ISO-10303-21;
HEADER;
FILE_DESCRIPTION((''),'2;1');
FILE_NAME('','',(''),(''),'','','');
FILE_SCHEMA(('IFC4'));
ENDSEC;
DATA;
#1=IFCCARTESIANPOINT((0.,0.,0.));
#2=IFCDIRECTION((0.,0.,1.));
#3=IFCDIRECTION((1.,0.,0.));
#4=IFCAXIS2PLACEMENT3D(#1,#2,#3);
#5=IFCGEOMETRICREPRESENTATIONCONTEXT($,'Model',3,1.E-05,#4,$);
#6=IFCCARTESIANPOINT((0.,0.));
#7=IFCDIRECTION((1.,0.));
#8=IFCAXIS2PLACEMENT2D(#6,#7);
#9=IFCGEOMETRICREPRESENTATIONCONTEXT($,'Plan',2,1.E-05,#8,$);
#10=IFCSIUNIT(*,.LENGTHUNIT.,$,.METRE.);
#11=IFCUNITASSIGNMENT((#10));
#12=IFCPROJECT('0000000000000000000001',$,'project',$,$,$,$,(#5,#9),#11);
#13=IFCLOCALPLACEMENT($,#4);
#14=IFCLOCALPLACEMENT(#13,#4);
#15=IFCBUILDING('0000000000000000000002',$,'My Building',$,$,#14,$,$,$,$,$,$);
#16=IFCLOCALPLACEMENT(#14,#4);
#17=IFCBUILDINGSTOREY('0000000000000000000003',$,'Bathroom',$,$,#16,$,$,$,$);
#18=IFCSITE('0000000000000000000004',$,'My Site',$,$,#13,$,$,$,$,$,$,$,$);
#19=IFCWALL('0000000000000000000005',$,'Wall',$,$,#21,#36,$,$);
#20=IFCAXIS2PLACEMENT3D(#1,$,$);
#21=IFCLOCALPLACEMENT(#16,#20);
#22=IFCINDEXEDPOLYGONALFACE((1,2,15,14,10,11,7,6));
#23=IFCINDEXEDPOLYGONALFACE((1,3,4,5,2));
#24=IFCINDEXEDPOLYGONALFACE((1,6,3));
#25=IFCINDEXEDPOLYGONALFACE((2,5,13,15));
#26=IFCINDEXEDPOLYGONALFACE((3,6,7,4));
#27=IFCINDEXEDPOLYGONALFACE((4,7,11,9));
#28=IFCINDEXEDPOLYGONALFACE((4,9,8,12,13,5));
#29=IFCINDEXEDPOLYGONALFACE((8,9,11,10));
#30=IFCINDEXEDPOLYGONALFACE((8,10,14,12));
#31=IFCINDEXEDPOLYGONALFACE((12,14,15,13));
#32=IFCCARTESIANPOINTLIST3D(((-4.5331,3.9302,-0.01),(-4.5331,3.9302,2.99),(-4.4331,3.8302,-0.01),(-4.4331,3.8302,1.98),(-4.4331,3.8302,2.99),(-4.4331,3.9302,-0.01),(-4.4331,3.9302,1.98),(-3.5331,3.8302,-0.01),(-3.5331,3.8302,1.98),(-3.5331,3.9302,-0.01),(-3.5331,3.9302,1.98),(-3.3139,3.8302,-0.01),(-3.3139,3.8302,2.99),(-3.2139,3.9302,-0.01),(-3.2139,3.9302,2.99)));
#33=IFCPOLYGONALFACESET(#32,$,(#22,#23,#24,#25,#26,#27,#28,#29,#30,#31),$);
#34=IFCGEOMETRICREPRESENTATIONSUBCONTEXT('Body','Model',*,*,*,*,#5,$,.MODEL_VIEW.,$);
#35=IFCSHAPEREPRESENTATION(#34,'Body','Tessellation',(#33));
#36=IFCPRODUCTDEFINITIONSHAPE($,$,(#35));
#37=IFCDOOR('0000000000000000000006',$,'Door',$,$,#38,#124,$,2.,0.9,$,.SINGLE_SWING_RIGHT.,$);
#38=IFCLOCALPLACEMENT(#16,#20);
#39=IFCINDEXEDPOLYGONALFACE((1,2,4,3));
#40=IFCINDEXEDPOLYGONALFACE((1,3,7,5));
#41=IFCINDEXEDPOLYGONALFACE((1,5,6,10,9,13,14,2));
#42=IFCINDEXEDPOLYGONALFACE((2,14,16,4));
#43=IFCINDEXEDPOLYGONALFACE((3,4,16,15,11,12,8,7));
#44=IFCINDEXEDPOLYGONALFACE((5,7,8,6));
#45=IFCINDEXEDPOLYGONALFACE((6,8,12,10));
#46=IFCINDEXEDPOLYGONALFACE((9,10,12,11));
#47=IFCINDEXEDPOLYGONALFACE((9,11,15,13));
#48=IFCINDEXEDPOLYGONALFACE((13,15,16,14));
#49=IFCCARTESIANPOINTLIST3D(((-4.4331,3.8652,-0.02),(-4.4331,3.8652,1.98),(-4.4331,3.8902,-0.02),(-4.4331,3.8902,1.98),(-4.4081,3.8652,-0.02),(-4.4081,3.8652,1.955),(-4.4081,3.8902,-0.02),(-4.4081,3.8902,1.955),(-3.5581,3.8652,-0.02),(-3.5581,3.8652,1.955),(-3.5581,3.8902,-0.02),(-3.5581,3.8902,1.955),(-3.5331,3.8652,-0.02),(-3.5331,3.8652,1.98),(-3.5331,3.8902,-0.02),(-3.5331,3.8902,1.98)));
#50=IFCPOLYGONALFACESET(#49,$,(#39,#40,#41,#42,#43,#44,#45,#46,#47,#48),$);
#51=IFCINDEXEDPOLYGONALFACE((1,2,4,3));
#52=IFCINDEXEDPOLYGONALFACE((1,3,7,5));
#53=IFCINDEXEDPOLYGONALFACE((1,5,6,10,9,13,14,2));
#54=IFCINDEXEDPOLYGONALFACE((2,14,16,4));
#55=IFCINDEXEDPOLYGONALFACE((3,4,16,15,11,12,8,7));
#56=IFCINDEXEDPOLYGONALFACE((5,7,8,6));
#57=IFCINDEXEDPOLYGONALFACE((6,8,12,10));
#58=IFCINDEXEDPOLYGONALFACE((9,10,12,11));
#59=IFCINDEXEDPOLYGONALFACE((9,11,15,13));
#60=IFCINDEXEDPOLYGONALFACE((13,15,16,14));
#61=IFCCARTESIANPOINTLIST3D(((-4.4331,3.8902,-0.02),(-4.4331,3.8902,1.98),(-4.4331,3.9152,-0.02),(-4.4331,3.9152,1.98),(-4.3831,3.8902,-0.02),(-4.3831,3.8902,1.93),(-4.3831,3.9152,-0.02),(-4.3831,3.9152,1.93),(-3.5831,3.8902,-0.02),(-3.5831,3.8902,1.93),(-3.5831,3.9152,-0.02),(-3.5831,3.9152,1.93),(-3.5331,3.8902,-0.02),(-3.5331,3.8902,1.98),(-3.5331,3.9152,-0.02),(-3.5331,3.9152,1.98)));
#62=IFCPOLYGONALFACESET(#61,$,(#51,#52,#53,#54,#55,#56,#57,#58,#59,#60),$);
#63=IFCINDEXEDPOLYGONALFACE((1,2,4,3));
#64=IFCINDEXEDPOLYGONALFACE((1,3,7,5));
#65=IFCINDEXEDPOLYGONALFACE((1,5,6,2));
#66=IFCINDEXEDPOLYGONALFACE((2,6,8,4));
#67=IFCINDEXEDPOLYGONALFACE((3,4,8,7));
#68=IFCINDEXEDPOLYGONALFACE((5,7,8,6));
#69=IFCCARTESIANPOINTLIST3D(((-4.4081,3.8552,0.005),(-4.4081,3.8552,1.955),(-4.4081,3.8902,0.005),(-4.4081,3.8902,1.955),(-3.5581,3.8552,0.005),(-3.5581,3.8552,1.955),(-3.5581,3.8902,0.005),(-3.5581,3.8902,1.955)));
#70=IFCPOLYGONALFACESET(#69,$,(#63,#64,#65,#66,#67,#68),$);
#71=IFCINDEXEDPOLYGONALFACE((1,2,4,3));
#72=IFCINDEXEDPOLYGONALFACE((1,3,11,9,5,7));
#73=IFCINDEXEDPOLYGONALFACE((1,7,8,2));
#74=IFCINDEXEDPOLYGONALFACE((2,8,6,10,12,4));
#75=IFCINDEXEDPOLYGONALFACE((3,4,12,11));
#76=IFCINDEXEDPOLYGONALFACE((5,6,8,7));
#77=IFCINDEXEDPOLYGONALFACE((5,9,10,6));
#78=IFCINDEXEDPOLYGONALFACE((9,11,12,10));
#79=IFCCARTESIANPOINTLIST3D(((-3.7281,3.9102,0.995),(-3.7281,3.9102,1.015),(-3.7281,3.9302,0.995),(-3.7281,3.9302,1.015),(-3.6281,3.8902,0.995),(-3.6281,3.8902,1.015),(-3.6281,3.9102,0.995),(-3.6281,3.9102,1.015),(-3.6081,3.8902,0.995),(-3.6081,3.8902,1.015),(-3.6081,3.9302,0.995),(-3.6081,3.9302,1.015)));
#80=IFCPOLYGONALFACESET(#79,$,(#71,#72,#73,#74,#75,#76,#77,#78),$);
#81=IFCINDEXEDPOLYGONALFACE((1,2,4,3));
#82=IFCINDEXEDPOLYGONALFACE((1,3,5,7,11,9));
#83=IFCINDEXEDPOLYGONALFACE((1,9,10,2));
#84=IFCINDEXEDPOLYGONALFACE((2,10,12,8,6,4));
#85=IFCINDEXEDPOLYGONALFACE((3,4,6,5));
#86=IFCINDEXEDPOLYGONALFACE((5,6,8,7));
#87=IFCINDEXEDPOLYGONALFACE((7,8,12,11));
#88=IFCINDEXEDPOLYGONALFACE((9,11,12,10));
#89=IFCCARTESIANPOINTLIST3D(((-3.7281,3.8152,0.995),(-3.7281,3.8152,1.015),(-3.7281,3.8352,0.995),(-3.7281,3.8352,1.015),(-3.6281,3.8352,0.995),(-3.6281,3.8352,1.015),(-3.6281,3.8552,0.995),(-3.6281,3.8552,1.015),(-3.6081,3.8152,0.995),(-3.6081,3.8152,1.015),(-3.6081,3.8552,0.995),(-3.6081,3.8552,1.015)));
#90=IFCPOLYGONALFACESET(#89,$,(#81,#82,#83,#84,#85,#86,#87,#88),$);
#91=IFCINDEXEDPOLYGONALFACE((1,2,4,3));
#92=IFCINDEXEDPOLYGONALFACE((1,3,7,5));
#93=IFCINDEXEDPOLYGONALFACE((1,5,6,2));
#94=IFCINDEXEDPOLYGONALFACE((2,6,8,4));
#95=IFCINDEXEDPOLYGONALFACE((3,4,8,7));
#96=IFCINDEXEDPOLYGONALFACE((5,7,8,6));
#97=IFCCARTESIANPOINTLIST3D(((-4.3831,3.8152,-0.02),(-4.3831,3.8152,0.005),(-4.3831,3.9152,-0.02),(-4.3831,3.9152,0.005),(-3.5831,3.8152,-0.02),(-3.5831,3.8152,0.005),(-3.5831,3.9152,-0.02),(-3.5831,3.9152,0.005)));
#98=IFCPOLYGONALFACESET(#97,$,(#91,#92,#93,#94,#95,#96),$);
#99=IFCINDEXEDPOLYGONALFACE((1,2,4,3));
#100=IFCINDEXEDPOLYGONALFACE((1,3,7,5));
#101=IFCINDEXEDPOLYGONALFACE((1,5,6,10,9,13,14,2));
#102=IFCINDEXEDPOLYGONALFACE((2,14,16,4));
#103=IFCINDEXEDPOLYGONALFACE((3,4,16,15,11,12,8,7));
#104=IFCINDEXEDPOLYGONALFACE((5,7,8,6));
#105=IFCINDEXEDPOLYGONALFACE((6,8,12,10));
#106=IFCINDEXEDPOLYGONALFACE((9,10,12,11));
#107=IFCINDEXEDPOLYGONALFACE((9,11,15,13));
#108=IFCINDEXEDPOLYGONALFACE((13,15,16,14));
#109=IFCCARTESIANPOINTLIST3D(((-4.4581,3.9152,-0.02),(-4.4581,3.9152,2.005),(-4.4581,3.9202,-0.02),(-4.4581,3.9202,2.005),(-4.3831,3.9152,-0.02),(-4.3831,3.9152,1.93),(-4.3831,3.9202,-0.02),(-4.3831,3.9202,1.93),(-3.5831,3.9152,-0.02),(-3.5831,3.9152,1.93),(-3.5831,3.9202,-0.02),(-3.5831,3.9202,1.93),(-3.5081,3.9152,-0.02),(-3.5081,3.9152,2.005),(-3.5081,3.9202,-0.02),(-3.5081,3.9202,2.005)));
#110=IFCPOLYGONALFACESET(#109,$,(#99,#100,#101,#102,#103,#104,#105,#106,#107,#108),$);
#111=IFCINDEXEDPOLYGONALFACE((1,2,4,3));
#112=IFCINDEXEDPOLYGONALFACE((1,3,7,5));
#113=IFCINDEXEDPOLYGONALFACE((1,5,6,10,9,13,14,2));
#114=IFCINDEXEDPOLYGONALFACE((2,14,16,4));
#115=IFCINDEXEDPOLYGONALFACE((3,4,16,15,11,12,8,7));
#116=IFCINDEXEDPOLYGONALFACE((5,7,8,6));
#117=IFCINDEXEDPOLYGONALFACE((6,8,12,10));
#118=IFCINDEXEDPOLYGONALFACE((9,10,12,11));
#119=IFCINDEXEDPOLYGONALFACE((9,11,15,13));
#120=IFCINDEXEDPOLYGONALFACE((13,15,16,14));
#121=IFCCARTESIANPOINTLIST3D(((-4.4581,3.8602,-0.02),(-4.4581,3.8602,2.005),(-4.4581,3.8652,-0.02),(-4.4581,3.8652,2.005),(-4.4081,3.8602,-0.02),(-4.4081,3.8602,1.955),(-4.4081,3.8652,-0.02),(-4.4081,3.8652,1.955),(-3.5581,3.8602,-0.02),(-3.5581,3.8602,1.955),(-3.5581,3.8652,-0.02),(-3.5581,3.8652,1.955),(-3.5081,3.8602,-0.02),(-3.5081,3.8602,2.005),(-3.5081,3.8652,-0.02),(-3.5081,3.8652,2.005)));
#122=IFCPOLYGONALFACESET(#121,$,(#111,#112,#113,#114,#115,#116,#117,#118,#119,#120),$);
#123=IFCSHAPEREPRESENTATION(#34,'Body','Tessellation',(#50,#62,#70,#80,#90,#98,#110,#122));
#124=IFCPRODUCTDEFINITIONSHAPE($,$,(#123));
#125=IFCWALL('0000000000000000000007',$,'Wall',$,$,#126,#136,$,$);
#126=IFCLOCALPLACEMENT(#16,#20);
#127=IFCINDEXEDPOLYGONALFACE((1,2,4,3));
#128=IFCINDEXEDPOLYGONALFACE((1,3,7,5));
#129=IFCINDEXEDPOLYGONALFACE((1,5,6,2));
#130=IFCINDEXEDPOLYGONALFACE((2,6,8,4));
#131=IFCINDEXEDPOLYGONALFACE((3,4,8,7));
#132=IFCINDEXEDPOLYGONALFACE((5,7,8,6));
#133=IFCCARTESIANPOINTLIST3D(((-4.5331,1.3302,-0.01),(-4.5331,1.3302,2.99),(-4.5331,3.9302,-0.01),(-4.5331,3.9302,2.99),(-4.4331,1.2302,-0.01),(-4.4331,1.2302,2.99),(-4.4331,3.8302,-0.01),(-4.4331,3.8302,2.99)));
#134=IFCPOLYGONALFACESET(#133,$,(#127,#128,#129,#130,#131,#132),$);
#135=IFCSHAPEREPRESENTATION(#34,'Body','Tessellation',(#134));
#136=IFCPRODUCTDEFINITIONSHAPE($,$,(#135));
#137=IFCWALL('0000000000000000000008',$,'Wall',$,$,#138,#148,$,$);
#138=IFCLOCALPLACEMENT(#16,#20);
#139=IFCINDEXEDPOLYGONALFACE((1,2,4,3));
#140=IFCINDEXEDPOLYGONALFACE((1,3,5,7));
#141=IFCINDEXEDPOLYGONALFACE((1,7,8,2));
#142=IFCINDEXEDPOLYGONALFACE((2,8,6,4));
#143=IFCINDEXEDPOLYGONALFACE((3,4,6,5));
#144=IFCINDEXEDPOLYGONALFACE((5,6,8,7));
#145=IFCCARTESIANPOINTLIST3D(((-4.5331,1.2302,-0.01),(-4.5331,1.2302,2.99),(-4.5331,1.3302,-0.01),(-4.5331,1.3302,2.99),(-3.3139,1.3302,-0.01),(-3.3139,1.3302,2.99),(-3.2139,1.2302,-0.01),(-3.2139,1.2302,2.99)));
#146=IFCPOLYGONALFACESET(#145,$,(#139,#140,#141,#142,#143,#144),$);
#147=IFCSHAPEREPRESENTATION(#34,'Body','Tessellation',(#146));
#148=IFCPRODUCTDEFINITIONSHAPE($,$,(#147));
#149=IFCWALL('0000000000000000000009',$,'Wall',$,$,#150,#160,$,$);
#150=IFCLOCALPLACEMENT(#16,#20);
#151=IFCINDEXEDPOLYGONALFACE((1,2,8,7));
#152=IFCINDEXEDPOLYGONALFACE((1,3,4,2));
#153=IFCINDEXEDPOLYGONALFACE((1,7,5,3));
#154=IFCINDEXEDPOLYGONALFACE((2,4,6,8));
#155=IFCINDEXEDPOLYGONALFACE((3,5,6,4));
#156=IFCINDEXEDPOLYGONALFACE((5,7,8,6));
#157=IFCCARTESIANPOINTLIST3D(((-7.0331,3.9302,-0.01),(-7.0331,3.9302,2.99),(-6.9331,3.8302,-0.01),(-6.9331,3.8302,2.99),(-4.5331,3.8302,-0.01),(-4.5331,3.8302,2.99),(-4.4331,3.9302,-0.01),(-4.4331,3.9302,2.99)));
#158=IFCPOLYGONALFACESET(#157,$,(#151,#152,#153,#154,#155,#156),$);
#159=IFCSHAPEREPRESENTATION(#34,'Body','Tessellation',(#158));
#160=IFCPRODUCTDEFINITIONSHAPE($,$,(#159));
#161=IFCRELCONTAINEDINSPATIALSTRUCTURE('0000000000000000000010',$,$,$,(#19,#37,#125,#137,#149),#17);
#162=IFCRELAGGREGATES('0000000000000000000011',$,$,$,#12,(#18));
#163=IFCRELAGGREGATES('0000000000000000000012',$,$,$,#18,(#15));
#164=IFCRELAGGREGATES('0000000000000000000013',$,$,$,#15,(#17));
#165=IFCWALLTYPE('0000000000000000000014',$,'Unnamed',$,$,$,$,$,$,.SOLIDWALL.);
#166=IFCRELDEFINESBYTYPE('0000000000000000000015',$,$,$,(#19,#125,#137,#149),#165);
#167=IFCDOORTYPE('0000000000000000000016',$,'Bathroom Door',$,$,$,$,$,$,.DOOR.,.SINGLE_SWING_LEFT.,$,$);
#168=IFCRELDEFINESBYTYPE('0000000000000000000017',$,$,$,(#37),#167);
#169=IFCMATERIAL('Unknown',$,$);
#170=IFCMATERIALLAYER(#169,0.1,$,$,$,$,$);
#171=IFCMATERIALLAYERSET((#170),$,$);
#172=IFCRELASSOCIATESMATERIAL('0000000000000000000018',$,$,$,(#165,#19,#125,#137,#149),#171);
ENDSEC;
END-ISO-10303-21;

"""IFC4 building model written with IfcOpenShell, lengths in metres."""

from ifc_helpers import new_model, entity, si_unit, frame, origin_with_axes, origin_2d_with_axis, place, context, subcontext, project, spatial, line, indexed_curve, outline, extrude, shape, source, transform, mapped, material, layer, layer_set, layer_usage, type_object, type_shapes, element, fill, save


model = new_model("IFC4")

# Units and contexts
model_context = context("Model", 3, precision=1e-05, world=origin_with_axes())
plan_context = context("Plan", 2, precision=1e-05, world=origin_2d_with_axis())
body_context_1 = subcontext(model_context, "Body", "Model", "MODEL_VIEW")
body_context_2 = subcontext(plan_context, "Body", "Plan", "PLAN_VIEW")
ifc_project = project(units=[si_unit("LENGTHUNIT", "METRE")], contexts=[model_context, plan_context])

# Site, building, storey
site_placement = place(None, origin_with_axes())
site = spatial("IfcSite", under=ifc_project, at=site_placement, Name="My Site")
building_placement = place(site_placement, origin_with_axes())
building = spatial("IfcBuilding", under=site, at=building_placement, Name="My Building")
storey_placement = place(building_placement, origin_with_axes())
storey = spatial("IfcBuildingStorey", under=building, at=storey_placement, Name="Bathroom")

# Shared definitions
ifc_material = material(Name="Unknown")

# Shared definitions
ifc_layer_1 = layer(ifc_material, 0.1)
ifc_layer_set_1 = layer_set([ifc_layer_1])
wall_type = type_object("IfcWallType", Name="Unnamed", PredefinedType="SOLIDWALL", material=ifc_layer_set_1)

# Shared definitions
shared_shape_1 = source(origin_with_axes(), body_context_1, "Body", "SweptSolid", [
    extrude(outline(indexed_curve([(0.0, 0.0), (0.9, 0.0), (0.9, 2.0), (0.0, 2.0)], segments=[line(1, 2, 3, 4, 1)])), frame((0.0, -0.6, 0.0), z_axis=(0.0, -1.0, 0.0), x_axis=(1.0, 0.0, 0.0)), (0.0, 0.0, -1.0), 1.2),
])
door_type = type_object("IfcDoorType", Name="Bathroom Door", OperationType="SINGLE_SWING_LEFT", PredefinedType="DOOR")
shared_shape_2 = source(origin_with_axes(), body_context_1, "Body", "SweptSolid", [
    extrude(outline(indexed_curve([(0.0, 0.0), (0.0, 2.0), (0.9, 2.0), (0.9, 0.0), (0.875, 0.0), (0.875, 1.975), (0.025, 1.975), (0.025, 0.0)], segments=[line(1, 2, 3, 4, 5, 6, 7, 8, 1)])), frame((0.0, 0.025, 0.0), z_axis=(0.0, -1.0, 0.0), x_axis=(1.0, 0.0, 0.0)), (0.0, 0.0, -1.0), 0.025),
    extrude(outline(indexed_curve([(0.0, 0.0), (0.0, 2.0), (0.9, 2.0), (0.9, 0.0), (0.85, 0.0), (0.85, 1.95), (0.05, 1.95), (0.05, 0.0)], segments=[line(1, 2, 3, 4, 5, 6, 7, 8, 1)])), frame((0.0, 0.0, 0.0), z_axis=(0.0, -1.0, 0.0), x_axis=(1.0, 0.0, 0.0)), (0.0, 0.0, -1.0), 0.025),
    extrude(outline(indexed_curve([(0.0, 0.0), (0.85, 0.0), (0.85, 0.035), (0.0, 0.035)], segments=[line(1, 2, 3, 4, 1)])), frame((0.025, 0.025, 0.025), z_axis=(0.0, 0.0, 1.0), x_axis=(1.0, 0.0, 0.0)), (0.0, 0.0, 1.0), 1.95),
    extrude(outline(indexed_curve([(0.0, 0.0), (0.0, -0.04), (0.12, -0.04), (0.12, -0.02), (0.02, -0.02), (0.02, 0.0)], segments=[line(1, 2, 3, 4, 5, 6, 1)])), frame((0.075, 0.025, 1.015), z_axis=(0.0, 0.0, 1.0), x_axis=(1.0, 0.0, 0.0)), (0.0, 0.0, 1.0), 0.02),
    extrude(outline(indexed_curve([(0.0, 0.0), (0.0, 0.04), (0.12, 0.04), (0.12, 0.02), (0.02, 0.02), (0.02, 0.0)], segments=[line(1, 2, 3, 4, 5, 6, 1)])), frame((0.075, 0.06, 1.015), z_axis=(0.0, 0.0, 1.0), x_axis=(1.0, 0.0, 0.0)), (0.0, 0.0, 1.0), 0.02),
    extrude(outline(indexed_curve([(0.0, 0.0), (0.8, 0.0), (0.8, 0.1), (0.0, 0.1)], segments=[line(1, 2, 3, 4, 1)])), frame((0.05, 0.0, 0.0), z_axis=(0.0, 0.0, 1.0), x_axis=(1.0, 0.0, 0.0)), (0.0, 0.0, 1.0), 0.025),
    extrude(outline(indexed_curve([(0.0, 0.0), (0.0, 2.025), (0.95, 2.025), (0.95, 0.0), (0.875, 0.0), (0.875, 1.95), (0.075, 1.95), (0.075, 0.0)], segments=[line(1, 2, 3, 4, 5, 6, 7, 8, 1)])), frame((-0.025, -0.005, 0.0), z_axis=(0.0, -1.0, 0.0), x_axis=(1.0, 0.0, 0.0)), (0.0, 0.0, -1.0), 0.005),
    extrude(outline(indexed_curve([(0.0, 0.0), (0.0, 2.025), (0.95, 2.025), (0.95, 0.0), (0.9, 0.0), (0.9, 1.975), (0.05, 1.975), (0.05, 0.0)], segments=[line(1, 2, 3, 4, 5, 6, 7, 8, 1)])), frame((-0.025, 0.05, 0.0), z_axis=(0.0, -1.0, 0.0), x_axis=(1.0, 0.0, 0.0)), (0.0, 0.0, -1.0), 0.005),
])
shared_shape_3 = source(origin_with_axes(), body_context_2, "Body", "Curve2D", [
    entity("IfcIndexedPolyCurve", entity("IfcCartesianPointList2D", [[0.0, 0.0], [0.0, 0.05], [0.025, 0.05], [0.025, 0.025], [0.05, 0.025], [0.05, 0.0]]), [entity("IfcLineIndex", [1, 2, 3, 4, 5, 6, 1])]),
    entity("IfcIndexedPolyCurve", entity("IfcCartesianPointList2D", [[0.9, 0.0], [0.9, 0.05], [0.875, 0.05], [0.875, 0.025], [0.85, 0.025], [0.85, 0.0]]), [entity("IfcLineIndex", [1, 2, 3, 4, 5, 6, 1])]),
    entity("IfcTrimmedCurve", entity("IfcEllipse", entity("IfcAxis2Placement2D", entity("IfcCartesianPoint", [0.84, 0.05]), entity("IfcDirection", [1.0, 0.0])), 0.815, 0.85), [entity("IfcCartesianPoint", [0.84, 0.9])], [entity("IfcCartesianPoint", [0.025, 0.05])], True, "CARTESIAN"),
    entity("IfcIndexedPolyCurve", entity("IfcCartesianPointList2D", [[0.875, 0.05], [0.84, 0.05], [0.84, 0.9], [0.875, 0.9]]), [entity("IfcLineIndex", [1, 2, 3, 4, 1])]),
])
type_shapes(door_type, [shared_shape_2, shared_shape_3])

# Wall, opening, door
ifc_layer_usage_1 = layer_usage(ifc_layer_set_1, "AXIS2", "POSITIVE", 0.0)
wall_1_placement = place(storey_placement, frame((-3.2139, 3.9302, -0.01), z_axis=(0.0, 0.0, 1.0), x_axis=(-1.0, 0.0, 0.0)))
wall_1 = element("IfcWall", 1, at=wall_1_placement, inside=storey, type_object=wall_type, material=ifc_layer_usage_1, Name="Wall", context=body_context_1, shape_type="SweptSolid", body=[
    extrude(outline(indexed_curve([(0.0, 0.0), (0.1, 0.1), (1.2192, 0.1), (1.3192, 0.0)], segments=[line(1, 2, 3, 4, 1)])), origin_with_axes(), (0.0, 0.0, 1.0), 3.0),
])
opening_1_placement = place(wall_1_placement, frame((0.3192, 0.015, -0.01), z_axis=(0.0, 0.0, 1.0), x_axis=(1.0, 0.0, 0.0)))
opening_1 = element("IfcOpeningElement", 2, at=opening_1_placement, cuts=wall_1, PredefinedType="OPENING", context=body_context_1, shape_type="MappedRepresentation", body=[
    mapped(shared_shape_1, transform((0.0, 0.0, 0.0), x_axis=(1.0, 0.0, 0.0), y_axis=(0.0, 1.0, 0.0), z_axis=(0.0, 0.0, 1.0), scale=1.0)),
])
door_1_placement = place(opening_1_placement, origin_with_axes())
door_1 = element("IfcDoor", 3, at=door_1_placement, inside=storey, type_object=door_type, Name="Door", OperationType="SINGLE_SWING_RIGHT", OverallHeight=2.0, OverallWidth=0.9, shapes=[
    shape(body_context_1, "Body", "MappedRepresentation", [mapped(shared_shape_2, transform((0.0, 0.0, 0.0), x_axis=(1.0, 0.0, 0.0), y_axis=(0.0, 1.0, 0.0), z_axis=(0.0, 0.0, 1.0), scale=1.0))]),
    shape(body_context_2, "Body", "MappedRepresentation", [mapped(shared_shape_3, transform((0.0, 0.0, 0.0), x_axis=(1.0, 0.0, 0.0), y_axis=(0.0, 1.0, 0.0), z_axis=(0.0, 0.0, 1.0), scale=1.0))]),
])
fill(opening_1, door_1)

# Walls
ifc_layer_usage_2 = layer_usage(ifc_layer_set_1, "AXIS2", "POSITIVE", 0.0)
wall_2_placement = place(storey_placement, frame((-4.5331, 3.9302, -0.01), z_axis=(0.0, 0.0, 1.0), x_axis=(0.0, -1.0, 0.0)))
element("IfcWall", 4, at=wall_2_placement, inside=storey, type_object=wall_type, material=ifc_layer_usage_2, Name="Wall", context=body_context_1, shape_type="SweptSolid", body=[
    extrude(outline(indexed_curve([(0.0, 0.0), (0.1, 0.1), (2.7, 0.1), (2.6, 0.0)], segments=[line(1, 2, 3, 4, 1)])), origin_with_axes(), (0.0, 0.0, 1.0), 3.0),
])
ifc_layer_usage_3 = layer_usage(ifc_layer_set_1, "AXIS2", "POSITIVE", 0.0)
wall_3_placement = place(storey_placement, frame((-4.5331, 1.2302, -0.01), z_axis=(0.0, 0.0, 1.0), x_axis=(1.0, 0.0, 0.0)))
element("IfcWall", 5, at=wall_3_placement, inside=storey, type_object=wall_type, material=ifc_layer_usage_3, Name="Wall", context=body_context_1, shape_type="SweptSolid", body=[
    extrude(outline(indexed_curve([(0.0, 0.0), (0.0, 0.1), (1.2192, 0.1), (1.3192, 0.0)], segments=[line(1, 2, 3, 4, 1)])), origin_with_axes(), (0.0, 0.0, 1.0), 3.0),
])
ifc_layer_usage_4 = layer_usage(ifc_layer_set_1, "AXIS2", "POSITIVE", 0.0)
wall_4_placement = place(storey_placement, frame((-4.5331, 3.9302, -0.01), z_axis=(0.0, 0.0, 1.0), x_axis=(-1.0, 0.0, 0.0)))
element("IfcWall", 6, at=wall_4_placement, inside=storey, type_object=wall_type, material=ifc_layer_usage_4, Name="Wall", context=body_context_1, shape_type="SweptSolid", body=[
    extrude(outline(indexed_curve([(-0.1, 0.0), (0.0, 0.1), (2.4, 0.1), (2.5, 0.0)], segments=[line(1, 2, 3, 4, 1)])), origin_with_axes(), (0.0, 0.0, 1.0), 3.0),
])

save(model, "model.ifc")
